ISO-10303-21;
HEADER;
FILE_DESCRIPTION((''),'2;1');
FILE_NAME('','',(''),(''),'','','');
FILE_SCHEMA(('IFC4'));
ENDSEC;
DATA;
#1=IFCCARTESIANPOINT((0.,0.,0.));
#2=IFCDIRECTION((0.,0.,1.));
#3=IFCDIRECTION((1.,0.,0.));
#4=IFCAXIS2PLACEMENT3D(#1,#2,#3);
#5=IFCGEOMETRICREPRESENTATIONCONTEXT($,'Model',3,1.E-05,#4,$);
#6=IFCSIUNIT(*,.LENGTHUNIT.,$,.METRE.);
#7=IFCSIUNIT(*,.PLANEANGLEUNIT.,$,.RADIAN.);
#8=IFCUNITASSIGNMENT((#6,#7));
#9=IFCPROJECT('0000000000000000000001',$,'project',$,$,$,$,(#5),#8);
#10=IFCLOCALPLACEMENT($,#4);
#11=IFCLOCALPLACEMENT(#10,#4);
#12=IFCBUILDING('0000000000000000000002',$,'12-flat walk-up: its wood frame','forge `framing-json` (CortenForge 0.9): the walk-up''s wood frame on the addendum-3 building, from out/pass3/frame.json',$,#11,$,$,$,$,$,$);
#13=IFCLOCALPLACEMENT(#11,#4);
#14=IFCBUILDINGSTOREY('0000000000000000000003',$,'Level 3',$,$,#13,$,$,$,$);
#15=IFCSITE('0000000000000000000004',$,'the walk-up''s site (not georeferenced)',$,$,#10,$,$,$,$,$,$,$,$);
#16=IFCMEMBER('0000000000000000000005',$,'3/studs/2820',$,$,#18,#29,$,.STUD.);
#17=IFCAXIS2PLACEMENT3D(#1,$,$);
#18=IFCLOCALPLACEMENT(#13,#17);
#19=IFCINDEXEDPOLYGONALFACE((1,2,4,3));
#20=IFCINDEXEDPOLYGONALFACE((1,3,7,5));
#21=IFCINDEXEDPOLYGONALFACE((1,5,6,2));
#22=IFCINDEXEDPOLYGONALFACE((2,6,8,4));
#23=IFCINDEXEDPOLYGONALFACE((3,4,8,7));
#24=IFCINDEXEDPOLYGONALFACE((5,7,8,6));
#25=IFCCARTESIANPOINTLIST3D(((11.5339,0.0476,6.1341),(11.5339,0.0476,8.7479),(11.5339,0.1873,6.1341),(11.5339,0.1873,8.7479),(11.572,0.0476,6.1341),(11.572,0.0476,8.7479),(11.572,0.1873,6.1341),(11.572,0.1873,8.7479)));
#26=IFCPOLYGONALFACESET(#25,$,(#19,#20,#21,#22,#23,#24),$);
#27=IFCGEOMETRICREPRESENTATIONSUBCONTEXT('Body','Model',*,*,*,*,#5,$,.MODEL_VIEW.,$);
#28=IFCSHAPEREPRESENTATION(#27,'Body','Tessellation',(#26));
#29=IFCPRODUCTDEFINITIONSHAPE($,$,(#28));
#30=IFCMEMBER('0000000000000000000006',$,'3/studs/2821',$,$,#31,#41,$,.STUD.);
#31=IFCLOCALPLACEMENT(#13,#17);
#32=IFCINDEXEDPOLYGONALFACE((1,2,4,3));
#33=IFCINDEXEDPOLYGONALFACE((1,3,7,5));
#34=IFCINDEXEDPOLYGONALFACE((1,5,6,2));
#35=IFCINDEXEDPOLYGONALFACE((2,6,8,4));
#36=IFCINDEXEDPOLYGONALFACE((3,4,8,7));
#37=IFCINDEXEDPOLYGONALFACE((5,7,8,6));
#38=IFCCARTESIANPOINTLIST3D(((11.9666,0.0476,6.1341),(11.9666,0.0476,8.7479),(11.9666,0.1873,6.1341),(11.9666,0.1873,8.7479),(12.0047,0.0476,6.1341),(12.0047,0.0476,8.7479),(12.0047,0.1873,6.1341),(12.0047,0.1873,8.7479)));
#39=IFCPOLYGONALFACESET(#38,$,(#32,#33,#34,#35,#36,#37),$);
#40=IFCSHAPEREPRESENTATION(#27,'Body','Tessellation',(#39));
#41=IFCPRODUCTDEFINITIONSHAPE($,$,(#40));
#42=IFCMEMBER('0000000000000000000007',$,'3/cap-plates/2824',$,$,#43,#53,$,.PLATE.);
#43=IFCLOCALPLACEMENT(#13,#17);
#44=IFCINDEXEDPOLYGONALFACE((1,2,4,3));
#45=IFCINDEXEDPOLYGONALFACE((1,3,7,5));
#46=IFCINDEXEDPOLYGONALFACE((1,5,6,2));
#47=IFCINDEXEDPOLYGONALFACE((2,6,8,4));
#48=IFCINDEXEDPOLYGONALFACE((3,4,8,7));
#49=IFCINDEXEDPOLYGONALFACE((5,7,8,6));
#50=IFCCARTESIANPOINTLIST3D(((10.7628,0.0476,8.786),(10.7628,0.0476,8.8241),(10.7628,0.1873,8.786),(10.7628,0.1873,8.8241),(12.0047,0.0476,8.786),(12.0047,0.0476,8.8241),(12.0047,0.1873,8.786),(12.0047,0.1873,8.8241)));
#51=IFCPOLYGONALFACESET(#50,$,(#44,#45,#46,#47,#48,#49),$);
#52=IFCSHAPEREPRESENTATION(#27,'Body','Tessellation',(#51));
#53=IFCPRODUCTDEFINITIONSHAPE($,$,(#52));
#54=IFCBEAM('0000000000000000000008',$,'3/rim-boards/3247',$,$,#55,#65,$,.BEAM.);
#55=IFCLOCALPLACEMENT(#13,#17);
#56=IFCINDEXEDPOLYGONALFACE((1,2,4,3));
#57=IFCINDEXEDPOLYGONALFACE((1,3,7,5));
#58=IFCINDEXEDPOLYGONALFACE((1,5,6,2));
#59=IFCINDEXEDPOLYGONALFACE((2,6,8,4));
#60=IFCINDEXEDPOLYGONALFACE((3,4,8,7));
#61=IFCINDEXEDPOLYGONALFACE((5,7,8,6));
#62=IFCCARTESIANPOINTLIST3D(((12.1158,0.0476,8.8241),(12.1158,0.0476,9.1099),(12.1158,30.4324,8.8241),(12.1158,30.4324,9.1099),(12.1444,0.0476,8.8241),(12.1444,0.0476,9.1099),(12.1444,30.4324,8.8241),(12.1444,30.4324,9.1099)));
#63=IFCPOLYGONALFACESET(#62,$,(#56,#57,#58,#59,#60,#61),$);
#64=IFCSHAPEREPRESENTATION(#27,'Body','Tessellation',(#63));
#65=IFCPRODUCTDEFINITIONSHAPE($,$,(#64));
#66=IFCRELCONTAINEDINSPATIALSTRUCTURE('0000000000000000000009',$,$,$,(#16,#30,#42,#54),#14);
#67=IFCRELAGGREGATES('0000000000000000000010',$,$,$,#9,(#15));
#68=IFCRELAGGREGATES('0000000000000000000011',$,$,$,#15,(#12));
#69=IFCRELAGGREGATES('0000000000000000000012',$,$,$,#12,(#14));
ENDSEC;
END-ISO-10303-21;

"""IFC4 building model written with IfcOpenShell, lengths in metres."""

from ifc_helpers import new_model, si_unit, frame, frame_2d, origin, origin_with_axes, place, context, subcontext, project, spatial, rectangle, extrude, element, save


model = new_model("IFC4")

# Units and contexts
model_context = context("Model", 3, precision=1e-05, world=origin_with_axes())
body_context = subcontext(model_context, "Body", "Model", "MODEL_VIEW")
ifc_project = project(units=[si_unit("LENGTHUNIT", "METRE"), si_unit("PLANEANGLEUNIT", "RADIAN")], contexts=[model_context])

# Site, building, storey
site_placement = place(None, origin_with_axes())
site = spatial("IfcSite", under=ifc_project, at=site_placement, Name="the walk-up's site (not georeferenced)")
building_placement = place(site_placement, origin_with_axes())
building = spatial("IfcBuilding", under=site, at=building_placement, Name="12-flat walk-up: its wood frame", Description="forge `framing-json` (CortenForge 0.9): the walk-up's wood frame on the addendum-3 building, from out/pass3/frame.json")
storey_placement = place(building_placement, origin_with_axes())
storey = spatial("IfcBuildingStorey", under=building, at=storey_placement, Name="Level 3")

# Members
for number, where, z_axis, x_axis, name in (
    (1, (11.5339, 0.0476, 6.1341), (0.0, 0.0, 1.0), (1.0, 0.0, 0.0), "3/studs/2820"),
    (2, (11.9666, 0.0476, 6.1341), (0.0, 0.0, 1.0), (1.0, 0.0, 0.0), "3/studs/2821"),
):
    element("IfcMember", number, at=place(storey_placement, frame(where, z_axis=z_axis, x_axis=x_axis)), inside=storey, Name=name, PredefinedType="STUD", context=body_context, shape_type="SweptSolid", body=[
        extrude(rectangle(XDim=0.0381, YDim=0.1397, at=frame_2d((0.0191, 0.0698))), origin(), (0.0, 0.0, 1.0), 2.6138),
    ])
member_1_placement = place(storey_placement, frame((10.7628, 0.0476, 8.786), z_axis=(0.0, 0.0, 1.0), x_axis=(1.0, 0.0, 0.0)))
element("IfcMember", 3, at=member_1_placement, inside=storey, Name="3/cap-plates/2824", PredefinedType="PLATE", context=body_context, shape_type="SweptSolid", body=[
    extrude(rectangle(XDim=1.2419, YDim=0.1397, at=frame_2d((0.6209, 0.0698))), origin(), (0.0, 0.0, 1.0), 0.0381),
])

# Beam
beam_placement = place(storey_placement, frame((12.1158, 0.0476, 8.8241), z_axis=(0.0, 0.0, 1.0), x_axis=(1.0, 0.0, 0.0)))
element("IfcBeam", 4, at=beam_placement, inside=storey, Name="3/rim-boards/3247", PredefinedType="BEAM", context=body_context, shape_type="SweptSolid", body=[
    extrude(rectangle(XDim=0.0286, YDim=30.3848, at=frame_2d((0.0143, 15.1924))), origin(), (0.0, 0.0, 1.0), 0.2858),
])

save(model, "model.ifc")
